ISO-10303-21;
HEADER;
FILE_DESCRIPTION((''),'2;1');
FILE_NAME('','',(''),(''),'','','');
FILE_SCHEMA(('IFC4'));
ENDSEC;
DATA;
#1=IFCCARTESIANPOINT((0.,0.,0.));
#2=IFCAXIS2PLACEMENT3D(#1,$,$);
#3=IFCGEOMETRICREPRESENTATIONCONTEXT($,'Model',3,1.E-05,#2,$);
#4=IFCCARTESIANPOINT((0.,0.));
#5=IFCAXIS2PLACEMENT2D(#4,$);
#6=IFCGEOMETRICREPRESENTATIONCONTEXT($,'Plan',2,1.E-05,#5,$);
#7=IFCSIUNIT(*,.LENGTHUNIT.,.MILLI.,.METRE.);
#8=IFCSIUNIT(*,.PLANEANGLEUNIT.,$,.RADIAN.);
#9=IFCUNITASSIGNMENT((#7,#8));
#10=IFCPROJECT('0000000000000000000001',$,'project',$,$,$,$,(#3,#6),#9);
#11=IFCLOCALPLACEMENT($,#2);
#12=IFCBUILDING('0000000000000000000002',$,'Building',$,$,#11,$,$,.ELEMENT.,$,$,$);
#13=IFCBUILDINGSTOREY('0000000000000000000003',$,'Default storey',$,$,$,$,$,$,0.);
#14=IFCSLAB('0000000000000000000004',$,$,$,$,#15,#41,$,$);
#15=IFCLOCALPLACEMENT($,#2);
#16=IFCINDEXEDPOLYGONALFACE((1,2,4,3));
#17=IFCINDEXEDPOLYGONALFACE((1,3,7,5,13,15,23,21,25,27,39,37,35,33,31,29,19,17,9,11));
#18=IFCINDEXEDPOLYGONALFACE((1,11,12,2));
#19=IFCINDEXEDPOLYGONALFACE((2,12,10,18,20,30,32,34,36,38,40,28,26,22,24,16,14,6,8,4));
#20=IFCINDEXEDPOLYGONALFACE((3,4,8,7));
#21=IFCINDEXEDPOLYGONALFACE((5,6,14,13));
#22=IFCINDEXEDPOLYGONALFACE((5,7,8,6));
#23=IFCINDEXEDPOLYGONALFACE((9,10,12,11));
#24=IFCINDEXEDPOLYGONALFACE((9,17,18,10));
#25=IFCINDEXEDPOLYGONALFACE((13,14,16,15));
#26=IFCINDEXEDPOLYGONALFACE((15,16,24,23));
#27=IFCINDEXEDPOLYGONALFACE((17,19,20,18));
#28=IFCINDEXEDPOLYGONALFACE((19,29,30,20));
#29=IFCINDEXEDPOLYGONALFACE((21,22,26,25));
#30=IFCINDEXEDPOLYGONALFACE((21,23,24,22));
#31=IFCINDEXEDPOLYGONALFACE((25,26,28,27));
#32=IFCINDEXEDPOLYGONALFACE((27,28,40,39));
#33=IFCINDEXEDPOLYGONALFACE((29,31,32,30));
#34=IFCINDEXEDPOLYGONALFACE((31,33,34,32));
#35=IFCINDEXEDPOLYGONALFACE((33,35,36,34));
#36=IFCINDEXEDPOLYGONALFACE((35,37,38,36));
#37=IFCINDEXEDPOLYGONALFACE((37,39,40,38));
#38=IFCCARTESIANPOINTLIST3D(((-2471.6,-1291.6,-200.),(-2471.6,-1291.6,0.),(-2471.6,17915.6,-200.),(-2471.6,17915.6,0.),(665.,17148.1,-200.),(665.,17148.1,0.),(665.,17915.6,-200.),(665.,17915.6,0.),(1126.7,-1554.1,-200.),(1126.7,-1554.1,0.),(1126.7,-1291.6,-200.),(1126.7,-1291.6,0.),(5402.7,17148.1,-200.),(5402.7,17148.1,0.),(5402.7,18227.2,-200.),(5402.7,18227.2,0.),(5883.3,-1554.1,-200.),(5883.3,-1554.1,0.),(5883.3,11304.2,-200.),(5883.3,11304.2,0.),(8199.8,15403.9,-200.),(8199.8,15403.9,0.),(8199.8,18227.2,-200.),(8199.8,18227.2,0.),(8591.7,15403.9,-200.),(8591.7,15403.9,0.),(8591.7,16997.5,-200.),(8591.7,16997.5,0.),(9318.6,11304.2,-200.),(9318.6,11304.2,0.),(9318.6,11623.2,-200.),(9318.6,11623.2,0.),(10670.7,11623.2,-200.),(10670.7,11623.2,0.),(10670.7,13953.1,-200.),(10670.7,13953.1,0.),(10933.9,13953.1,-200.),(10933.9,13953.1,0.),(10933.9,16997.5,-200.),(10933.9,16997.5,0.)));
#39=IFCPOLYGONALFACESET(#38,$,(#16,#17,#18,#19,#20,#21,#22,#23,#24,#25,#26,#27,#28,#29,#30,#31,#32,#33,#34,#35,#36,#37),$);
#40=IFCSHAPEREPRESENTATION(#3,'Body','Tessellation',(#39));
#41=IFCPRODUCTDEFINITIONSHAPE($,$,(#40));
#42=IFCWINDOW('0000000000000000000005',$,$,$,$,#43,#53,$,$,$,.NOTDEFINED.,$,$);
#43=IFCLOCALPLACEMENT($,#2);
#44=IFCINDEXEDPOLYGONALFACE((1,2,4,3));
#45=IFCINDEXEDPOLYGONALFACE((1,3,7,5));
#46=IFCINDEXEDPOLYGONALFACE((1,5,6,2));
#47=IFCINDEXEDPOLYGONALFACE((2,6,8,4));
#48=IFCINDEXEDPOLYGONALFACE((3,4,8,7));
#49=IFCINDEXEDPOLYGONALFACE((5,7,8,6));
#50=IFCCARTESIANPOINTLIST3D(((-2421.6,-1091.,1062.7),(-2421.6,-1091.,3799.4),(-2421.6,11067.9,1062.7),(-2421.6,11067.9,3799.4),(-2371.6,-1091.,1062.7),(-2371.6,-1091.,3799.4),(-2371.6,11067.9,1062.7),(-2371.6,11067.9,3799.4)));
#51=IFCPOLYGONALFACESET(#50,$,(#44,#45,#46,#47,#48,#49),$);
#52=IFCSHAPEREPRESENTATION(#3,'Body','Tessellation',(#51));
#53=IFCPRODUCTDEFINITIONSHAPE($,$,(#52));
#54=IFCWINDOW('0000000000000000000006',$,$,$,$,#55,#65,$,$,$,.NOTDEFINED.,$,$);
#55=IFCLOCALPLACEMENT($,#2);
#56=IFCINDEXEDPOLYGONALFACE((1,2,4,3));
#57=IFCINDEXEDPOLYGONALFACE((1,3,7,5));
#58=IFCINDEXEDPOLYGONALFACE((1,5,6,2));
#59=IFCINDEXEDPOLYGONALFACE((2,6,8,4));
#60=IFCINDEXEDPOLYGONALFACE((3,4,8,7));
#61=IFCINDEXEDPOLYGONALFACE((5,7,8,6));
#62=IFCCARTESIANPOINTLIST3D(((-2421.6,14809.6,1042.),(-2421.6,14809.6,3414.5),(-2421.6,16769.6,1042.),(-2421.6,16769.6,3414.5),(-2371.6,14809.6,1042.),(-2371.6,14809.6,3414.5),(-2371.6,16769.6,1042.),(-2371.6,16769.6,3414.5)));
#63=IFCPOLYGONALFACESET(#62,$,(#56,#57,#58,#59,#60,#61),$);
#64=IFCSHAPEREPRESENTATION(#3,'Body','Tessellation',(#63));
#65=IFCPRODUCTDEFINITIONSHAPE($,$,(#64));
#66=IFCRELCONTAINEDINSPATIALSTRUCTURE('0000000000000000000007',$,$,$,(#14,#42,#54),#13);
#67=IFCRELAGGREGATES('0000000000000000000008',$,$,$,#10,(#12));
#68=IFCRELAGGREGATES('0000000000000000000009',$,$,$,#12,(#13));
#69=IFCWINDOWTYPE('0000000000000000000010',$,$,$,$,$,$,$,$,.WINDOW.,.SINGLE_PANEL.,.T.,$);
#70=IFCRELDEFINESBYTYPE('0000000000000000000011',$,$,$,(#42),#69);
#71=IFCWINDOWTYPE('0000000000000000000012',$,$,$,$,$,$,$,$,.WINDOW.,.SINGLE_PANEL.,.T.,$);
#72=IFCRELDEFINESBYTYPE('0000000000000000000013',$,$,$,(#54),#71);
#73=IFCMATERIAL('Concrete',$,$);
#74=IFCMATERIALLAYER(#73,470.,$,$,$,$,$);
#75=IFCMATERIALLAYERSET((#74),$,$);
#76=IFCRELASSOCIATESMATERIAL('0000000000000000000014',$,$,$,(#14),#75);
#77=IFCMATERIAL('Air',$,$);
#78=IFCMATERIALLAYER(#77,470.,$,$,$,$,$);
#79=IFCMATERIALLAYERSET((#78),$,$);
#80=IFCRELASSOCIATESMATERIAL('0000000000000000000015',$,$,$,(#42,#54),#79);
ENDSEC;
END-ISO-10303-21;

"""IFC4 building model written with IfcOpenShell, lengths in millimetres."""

from ifc_helpers import new_model, si_unit, frame, origin, origin_2d, place, context, project, spatial, polyline, rectangle, outline, extrude, material, layer, layer_set, layer_usage, type_object, element, save


model = new_model("IFC4")

# Units and contexts
model_context = context("Model", 3, precision=1e-05, world=origin())
plan_context = context("Plan", 2, precision=1e-05, world=origin_2d())
ifc_project = project(units=[si_unit("LENGTHUNIT", "METRE", prefix="MILLI"), si_unit("PLANEANGLEUNIT", "RADIAN")], contexts=[model_context, plan_context])

# Building, storey
placement = place(None, origin())
building = spatial("IfcBuilding", under=ifc_project, at=placement, Name="Building", CompositionType="ELEMENT")
storey = spatial("IfcBuildingStorey", under=building, Name="Default storey", Elevation=0.0)

# Slab
ifc_material_1 = material(Name="Concrete")
ifc_layer_1 = layer(ifc_material_1, 470.0)
ifc_layer_set_1 = layer_set([ifc_layer_1])
ifc_layer_usage_1 = layer_usage(ifc_layer_set_1, "AXIS3", "POSITIVE", 0.0)
element("IfcSlab", 1, at=placement, inside=storey, material=ifc_layer_usage_1, context=model_context, shape_type="SweptSolid", body=[
    extrude(outline(polyline([(8591.7, 16997.5), (8591.7, 15403.9), (8199.8, 15403.9), (8199.8, 18227.2), (5402.7, 18227.2), (5402.7, 17148.1), (665.0, 17148.1), (665.0, 17915.6), (-2471.6, 17915.6), (-2471.6, -1291.6), (1126.7, -1291.6), (1126.7, -1554.1), (5883.3, -1554.1), (5883.3, 11304.2), (9318.6, 11304.2), (9318.6, 11623.2), (10670.7, 11623.2), (10670.7, 13953.1), (10933.9, 13953.1), (10933.9, 16997.5), (8591.7, 16997.5)])), frame((0.0, 0.0, -200.0), z_axis=(0.0, 0.0, 1000.0), x_axis=(1000.0, 0.0, 0.0)), (0.0, 0.0, 1.0), 200.0),
])

# Windows
ifc_material_2 = material(Name="Air")
ifc_layer_2 = layer(ifc_material_2, 470.0)
ifc_layer_set_2 = layer_set([ifc_layer_2])
ifc_layer_usage_2 = layer_usage(ifc_layer_set_2, "AXIS3", "POSITIVE", 0.0)
window_type_1 = type_object("IfcWindowType", ParameterTakesPrecedence=True, PartitioningType="SINGLE_PANEL", PredefinedType="WINDOW")
element("IfcWindow", 2, at=placement, inside=storey, type_object=window_type_1, material=ifc_layer_usage_2, PredefinedType="NOTDEFINED", context=model_context, shape_type="CSG", body=[
    extrude(rectangle(XDim=12158.9, YDim=50.0, at=origin_2d()), frame((-2396.6, 4988.4, 1062.7), z_axis=(0.0, 0.0, 1000.0), x_axis=(0.0, 12158.909678, 0.0)), (0.0, 0.0, 1.0), 2736.7),
])
window_type_2 = type_object("IfcWindowType", ParameterTakesPrecedence=True, PartitioningType="SINGLE_PANEL", PredefinedType="WINDOW")
element("IfcWindow", 3, at=placement, inside=storey, type_object=window_type_2, material=ifc_layer_usage_2, PredefinedType="NOTDEFINED", context=model_context, shape_type="CSG", body=[
    extrude(rectangle(XDim=1960.0, YDim=50.0, at=origin_2d()), frame((-2396.6, 15789.6, 1042.0), z_axis=(0.0, 0.0, 1000.0), x_axis=(0.0, 1960.000038, 0.0)), (0.0, 0.0, 1.0), 2372.5),
])

save(model, "model.ifc")
